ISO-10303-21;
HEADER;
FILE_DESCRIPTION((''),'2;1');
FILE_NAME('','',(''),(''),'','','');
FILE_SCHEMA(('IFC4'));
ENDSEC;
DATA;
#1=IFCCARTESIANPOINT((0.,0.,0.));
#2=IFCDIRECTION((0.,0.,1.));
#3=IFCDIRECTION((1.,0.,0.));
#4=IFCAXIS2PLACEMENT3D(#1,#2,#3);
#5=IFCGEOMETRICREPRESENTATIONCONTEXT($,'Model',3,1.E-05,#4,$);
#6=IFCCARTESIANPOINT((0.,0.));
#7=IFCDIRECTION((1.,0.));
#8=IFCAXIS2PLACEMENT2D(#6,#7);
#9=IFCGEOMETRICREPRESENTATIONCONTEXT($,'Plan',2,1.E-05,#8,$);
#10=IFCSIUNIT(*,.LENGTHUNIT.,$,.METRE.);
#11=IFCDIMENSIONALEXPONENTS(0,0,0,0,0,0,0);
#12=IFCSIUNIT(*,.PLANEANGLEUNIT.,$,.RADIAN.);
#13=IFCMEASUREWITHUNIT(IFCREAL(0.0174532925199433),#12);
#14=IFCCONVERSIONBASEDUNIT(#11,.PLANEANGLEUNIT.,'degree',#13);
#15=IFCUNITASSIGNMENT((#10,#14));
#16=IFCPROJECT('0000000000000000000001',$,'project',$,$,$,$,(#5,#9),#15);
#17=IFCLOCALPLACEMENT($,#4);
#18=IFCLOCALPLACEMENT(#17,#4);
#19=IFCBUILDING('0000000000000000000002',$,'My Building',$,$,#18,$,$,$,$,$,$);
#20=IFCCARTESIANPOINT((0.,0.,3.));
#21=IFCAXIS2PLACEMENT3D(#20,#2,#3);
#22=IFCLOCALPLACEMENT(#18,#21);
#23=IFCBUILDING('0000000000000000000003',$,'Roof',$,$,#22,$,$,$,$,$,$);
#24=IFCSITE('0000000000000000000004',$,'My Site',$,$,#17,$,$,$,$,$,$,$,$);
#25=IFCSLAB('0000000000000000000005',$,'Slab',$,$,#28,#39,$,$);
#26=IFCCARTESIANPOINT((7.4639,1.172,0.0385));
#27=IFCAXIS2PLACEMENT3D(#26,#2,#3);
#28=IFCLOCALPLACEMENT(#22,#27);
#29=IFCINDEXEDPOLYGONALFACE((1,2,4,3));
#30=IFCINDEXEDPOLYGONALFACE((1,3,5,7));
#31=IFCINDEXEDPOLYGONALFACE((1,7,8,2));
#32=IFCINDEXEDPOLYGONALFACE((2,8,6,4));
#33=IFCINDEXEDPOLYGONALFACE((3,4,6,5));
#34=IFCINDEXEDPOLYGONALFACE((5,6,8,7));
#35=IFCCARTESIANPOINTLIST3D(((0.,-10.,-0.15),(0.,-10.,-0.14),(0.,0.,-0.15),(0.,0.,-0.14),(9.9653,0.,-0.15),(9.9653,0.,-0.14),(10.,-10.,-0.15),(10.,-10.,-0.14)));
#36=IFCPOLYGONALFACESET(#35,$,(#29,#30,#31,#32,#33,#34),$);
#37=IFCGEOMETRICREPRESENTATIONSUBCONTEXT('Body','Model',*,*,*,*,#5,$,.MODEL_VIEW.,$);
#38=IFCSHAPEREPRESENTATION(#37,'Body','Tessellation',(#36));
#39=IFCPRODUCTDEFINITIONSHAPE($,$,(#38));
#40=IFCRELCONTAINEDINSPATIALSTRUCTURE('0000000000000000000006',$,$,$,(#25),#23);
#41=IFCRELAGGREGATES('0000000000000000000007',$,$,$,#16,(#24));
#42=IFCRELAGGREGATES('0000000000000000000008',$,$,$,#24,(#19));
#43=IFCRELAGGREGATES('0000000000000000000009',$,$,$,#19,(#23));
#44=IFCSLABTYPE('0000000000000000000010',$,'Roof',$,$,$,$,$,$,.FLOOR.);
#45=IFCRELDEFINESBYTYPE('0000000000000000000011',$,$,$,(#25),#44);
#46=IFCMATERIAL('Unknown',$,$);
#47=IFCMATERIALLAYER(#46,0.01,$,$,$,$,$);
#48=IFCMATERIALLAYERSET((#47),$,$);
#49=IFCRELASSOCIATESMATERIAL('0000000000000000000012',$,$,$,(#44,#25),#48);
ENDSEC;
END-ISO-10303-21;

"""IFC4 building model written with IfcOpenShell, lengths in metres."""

from ifc_helpers import new_model, entity, si_unit, converted_unit, frame, origin_with_axes, origin_2d_with_axis, place, context, subcontext, project, spatial, indexed_curve, outline, extrude, material, layer, layer_set, layer_usage, type_object, element, save


model = new_model("IFC4")

# Units and contexts
model_context = context("Model", 3, precision=1e-05, world=origin_with_axes())
plan_context = context("Plan", 2, precision=1e-05, world=origin_2d_with_axis())
body_context = subcontext(model_context, "Body", "Model", "MODEL_VIEW")
ifc_project = project(units=[si_unit("LENGTHUNIT", "METRE"), converted_unit("PLANEANGLEUNIT", "degree", entity("IfcReal", 0.0174532925199433), si_unit("PLANEANGLEUNIT", "RADIAN"), dimensions=[0, 0, 0, 0, 0, 0, 0])], contexts=[model_context, plan_context])

# Site, buildings
site_placement = place(None, origin_with_axes())
site = spatial("IfcSite", under=ifc_project, at=site_placement, Name="My Site")
building_1_placement = place(site_placement, origin_with_axes())
building_1 = spatial("IfcBuilding", under=site, at=building_1_placement, Name="My Building")
building_2_placement = place(building_1_placement, frame((0.0, 0.0, 3.0), z_axis=(0.0, 0.0, 1.0), x_axis=(1.0, 0.0, 0.0)))
building_2 = spatial("IfcBuilding", under=building_1, at=building_2_placement, Name="Roof")

# Slab
ifc_material = material(Name="Unknown")
ifc_layer = layer(ifc_material, 0.01)
ifc_layer_set = layer_set([ifc_layer])
ifc_layer_usage = layer_usage(ifc_layer_set, "AXIS3", "POSITIVE", -0.15)
slab_type = type_object("IfcSlabType", Name="Roof", PredefinedType="FLOOR", material=ifc_layer_set)
slab_placement = place(building_2_placement, frame((7.4639, 1.172, 0.0385), z_axis=(0.0, 0.0, 1.0), x_axis=(1.0, 0.0, 0.0)))
element("IfcSlab", 1, at=slab_placement, inside=building_2, type_object=slab_type, material=ifc_layer_usage, Name="Slab", context=body_context, shape_type="SweptSolid", body=[
    extrude(outline(indexed_curve([(0.0, 0.0), (9.9653, 0.0), (10.0, -10.0), (0.0, -10.0), (0.0, 0.0)])), frame((0.0, 0.0, -0.15), z_axis=(0.0, 0.0, 1.0), x_axis=(1.0, 0.0, 0.0)), (0.0, 0.0, 1.0), 0.01),
])

save(model, "model.ifc")
